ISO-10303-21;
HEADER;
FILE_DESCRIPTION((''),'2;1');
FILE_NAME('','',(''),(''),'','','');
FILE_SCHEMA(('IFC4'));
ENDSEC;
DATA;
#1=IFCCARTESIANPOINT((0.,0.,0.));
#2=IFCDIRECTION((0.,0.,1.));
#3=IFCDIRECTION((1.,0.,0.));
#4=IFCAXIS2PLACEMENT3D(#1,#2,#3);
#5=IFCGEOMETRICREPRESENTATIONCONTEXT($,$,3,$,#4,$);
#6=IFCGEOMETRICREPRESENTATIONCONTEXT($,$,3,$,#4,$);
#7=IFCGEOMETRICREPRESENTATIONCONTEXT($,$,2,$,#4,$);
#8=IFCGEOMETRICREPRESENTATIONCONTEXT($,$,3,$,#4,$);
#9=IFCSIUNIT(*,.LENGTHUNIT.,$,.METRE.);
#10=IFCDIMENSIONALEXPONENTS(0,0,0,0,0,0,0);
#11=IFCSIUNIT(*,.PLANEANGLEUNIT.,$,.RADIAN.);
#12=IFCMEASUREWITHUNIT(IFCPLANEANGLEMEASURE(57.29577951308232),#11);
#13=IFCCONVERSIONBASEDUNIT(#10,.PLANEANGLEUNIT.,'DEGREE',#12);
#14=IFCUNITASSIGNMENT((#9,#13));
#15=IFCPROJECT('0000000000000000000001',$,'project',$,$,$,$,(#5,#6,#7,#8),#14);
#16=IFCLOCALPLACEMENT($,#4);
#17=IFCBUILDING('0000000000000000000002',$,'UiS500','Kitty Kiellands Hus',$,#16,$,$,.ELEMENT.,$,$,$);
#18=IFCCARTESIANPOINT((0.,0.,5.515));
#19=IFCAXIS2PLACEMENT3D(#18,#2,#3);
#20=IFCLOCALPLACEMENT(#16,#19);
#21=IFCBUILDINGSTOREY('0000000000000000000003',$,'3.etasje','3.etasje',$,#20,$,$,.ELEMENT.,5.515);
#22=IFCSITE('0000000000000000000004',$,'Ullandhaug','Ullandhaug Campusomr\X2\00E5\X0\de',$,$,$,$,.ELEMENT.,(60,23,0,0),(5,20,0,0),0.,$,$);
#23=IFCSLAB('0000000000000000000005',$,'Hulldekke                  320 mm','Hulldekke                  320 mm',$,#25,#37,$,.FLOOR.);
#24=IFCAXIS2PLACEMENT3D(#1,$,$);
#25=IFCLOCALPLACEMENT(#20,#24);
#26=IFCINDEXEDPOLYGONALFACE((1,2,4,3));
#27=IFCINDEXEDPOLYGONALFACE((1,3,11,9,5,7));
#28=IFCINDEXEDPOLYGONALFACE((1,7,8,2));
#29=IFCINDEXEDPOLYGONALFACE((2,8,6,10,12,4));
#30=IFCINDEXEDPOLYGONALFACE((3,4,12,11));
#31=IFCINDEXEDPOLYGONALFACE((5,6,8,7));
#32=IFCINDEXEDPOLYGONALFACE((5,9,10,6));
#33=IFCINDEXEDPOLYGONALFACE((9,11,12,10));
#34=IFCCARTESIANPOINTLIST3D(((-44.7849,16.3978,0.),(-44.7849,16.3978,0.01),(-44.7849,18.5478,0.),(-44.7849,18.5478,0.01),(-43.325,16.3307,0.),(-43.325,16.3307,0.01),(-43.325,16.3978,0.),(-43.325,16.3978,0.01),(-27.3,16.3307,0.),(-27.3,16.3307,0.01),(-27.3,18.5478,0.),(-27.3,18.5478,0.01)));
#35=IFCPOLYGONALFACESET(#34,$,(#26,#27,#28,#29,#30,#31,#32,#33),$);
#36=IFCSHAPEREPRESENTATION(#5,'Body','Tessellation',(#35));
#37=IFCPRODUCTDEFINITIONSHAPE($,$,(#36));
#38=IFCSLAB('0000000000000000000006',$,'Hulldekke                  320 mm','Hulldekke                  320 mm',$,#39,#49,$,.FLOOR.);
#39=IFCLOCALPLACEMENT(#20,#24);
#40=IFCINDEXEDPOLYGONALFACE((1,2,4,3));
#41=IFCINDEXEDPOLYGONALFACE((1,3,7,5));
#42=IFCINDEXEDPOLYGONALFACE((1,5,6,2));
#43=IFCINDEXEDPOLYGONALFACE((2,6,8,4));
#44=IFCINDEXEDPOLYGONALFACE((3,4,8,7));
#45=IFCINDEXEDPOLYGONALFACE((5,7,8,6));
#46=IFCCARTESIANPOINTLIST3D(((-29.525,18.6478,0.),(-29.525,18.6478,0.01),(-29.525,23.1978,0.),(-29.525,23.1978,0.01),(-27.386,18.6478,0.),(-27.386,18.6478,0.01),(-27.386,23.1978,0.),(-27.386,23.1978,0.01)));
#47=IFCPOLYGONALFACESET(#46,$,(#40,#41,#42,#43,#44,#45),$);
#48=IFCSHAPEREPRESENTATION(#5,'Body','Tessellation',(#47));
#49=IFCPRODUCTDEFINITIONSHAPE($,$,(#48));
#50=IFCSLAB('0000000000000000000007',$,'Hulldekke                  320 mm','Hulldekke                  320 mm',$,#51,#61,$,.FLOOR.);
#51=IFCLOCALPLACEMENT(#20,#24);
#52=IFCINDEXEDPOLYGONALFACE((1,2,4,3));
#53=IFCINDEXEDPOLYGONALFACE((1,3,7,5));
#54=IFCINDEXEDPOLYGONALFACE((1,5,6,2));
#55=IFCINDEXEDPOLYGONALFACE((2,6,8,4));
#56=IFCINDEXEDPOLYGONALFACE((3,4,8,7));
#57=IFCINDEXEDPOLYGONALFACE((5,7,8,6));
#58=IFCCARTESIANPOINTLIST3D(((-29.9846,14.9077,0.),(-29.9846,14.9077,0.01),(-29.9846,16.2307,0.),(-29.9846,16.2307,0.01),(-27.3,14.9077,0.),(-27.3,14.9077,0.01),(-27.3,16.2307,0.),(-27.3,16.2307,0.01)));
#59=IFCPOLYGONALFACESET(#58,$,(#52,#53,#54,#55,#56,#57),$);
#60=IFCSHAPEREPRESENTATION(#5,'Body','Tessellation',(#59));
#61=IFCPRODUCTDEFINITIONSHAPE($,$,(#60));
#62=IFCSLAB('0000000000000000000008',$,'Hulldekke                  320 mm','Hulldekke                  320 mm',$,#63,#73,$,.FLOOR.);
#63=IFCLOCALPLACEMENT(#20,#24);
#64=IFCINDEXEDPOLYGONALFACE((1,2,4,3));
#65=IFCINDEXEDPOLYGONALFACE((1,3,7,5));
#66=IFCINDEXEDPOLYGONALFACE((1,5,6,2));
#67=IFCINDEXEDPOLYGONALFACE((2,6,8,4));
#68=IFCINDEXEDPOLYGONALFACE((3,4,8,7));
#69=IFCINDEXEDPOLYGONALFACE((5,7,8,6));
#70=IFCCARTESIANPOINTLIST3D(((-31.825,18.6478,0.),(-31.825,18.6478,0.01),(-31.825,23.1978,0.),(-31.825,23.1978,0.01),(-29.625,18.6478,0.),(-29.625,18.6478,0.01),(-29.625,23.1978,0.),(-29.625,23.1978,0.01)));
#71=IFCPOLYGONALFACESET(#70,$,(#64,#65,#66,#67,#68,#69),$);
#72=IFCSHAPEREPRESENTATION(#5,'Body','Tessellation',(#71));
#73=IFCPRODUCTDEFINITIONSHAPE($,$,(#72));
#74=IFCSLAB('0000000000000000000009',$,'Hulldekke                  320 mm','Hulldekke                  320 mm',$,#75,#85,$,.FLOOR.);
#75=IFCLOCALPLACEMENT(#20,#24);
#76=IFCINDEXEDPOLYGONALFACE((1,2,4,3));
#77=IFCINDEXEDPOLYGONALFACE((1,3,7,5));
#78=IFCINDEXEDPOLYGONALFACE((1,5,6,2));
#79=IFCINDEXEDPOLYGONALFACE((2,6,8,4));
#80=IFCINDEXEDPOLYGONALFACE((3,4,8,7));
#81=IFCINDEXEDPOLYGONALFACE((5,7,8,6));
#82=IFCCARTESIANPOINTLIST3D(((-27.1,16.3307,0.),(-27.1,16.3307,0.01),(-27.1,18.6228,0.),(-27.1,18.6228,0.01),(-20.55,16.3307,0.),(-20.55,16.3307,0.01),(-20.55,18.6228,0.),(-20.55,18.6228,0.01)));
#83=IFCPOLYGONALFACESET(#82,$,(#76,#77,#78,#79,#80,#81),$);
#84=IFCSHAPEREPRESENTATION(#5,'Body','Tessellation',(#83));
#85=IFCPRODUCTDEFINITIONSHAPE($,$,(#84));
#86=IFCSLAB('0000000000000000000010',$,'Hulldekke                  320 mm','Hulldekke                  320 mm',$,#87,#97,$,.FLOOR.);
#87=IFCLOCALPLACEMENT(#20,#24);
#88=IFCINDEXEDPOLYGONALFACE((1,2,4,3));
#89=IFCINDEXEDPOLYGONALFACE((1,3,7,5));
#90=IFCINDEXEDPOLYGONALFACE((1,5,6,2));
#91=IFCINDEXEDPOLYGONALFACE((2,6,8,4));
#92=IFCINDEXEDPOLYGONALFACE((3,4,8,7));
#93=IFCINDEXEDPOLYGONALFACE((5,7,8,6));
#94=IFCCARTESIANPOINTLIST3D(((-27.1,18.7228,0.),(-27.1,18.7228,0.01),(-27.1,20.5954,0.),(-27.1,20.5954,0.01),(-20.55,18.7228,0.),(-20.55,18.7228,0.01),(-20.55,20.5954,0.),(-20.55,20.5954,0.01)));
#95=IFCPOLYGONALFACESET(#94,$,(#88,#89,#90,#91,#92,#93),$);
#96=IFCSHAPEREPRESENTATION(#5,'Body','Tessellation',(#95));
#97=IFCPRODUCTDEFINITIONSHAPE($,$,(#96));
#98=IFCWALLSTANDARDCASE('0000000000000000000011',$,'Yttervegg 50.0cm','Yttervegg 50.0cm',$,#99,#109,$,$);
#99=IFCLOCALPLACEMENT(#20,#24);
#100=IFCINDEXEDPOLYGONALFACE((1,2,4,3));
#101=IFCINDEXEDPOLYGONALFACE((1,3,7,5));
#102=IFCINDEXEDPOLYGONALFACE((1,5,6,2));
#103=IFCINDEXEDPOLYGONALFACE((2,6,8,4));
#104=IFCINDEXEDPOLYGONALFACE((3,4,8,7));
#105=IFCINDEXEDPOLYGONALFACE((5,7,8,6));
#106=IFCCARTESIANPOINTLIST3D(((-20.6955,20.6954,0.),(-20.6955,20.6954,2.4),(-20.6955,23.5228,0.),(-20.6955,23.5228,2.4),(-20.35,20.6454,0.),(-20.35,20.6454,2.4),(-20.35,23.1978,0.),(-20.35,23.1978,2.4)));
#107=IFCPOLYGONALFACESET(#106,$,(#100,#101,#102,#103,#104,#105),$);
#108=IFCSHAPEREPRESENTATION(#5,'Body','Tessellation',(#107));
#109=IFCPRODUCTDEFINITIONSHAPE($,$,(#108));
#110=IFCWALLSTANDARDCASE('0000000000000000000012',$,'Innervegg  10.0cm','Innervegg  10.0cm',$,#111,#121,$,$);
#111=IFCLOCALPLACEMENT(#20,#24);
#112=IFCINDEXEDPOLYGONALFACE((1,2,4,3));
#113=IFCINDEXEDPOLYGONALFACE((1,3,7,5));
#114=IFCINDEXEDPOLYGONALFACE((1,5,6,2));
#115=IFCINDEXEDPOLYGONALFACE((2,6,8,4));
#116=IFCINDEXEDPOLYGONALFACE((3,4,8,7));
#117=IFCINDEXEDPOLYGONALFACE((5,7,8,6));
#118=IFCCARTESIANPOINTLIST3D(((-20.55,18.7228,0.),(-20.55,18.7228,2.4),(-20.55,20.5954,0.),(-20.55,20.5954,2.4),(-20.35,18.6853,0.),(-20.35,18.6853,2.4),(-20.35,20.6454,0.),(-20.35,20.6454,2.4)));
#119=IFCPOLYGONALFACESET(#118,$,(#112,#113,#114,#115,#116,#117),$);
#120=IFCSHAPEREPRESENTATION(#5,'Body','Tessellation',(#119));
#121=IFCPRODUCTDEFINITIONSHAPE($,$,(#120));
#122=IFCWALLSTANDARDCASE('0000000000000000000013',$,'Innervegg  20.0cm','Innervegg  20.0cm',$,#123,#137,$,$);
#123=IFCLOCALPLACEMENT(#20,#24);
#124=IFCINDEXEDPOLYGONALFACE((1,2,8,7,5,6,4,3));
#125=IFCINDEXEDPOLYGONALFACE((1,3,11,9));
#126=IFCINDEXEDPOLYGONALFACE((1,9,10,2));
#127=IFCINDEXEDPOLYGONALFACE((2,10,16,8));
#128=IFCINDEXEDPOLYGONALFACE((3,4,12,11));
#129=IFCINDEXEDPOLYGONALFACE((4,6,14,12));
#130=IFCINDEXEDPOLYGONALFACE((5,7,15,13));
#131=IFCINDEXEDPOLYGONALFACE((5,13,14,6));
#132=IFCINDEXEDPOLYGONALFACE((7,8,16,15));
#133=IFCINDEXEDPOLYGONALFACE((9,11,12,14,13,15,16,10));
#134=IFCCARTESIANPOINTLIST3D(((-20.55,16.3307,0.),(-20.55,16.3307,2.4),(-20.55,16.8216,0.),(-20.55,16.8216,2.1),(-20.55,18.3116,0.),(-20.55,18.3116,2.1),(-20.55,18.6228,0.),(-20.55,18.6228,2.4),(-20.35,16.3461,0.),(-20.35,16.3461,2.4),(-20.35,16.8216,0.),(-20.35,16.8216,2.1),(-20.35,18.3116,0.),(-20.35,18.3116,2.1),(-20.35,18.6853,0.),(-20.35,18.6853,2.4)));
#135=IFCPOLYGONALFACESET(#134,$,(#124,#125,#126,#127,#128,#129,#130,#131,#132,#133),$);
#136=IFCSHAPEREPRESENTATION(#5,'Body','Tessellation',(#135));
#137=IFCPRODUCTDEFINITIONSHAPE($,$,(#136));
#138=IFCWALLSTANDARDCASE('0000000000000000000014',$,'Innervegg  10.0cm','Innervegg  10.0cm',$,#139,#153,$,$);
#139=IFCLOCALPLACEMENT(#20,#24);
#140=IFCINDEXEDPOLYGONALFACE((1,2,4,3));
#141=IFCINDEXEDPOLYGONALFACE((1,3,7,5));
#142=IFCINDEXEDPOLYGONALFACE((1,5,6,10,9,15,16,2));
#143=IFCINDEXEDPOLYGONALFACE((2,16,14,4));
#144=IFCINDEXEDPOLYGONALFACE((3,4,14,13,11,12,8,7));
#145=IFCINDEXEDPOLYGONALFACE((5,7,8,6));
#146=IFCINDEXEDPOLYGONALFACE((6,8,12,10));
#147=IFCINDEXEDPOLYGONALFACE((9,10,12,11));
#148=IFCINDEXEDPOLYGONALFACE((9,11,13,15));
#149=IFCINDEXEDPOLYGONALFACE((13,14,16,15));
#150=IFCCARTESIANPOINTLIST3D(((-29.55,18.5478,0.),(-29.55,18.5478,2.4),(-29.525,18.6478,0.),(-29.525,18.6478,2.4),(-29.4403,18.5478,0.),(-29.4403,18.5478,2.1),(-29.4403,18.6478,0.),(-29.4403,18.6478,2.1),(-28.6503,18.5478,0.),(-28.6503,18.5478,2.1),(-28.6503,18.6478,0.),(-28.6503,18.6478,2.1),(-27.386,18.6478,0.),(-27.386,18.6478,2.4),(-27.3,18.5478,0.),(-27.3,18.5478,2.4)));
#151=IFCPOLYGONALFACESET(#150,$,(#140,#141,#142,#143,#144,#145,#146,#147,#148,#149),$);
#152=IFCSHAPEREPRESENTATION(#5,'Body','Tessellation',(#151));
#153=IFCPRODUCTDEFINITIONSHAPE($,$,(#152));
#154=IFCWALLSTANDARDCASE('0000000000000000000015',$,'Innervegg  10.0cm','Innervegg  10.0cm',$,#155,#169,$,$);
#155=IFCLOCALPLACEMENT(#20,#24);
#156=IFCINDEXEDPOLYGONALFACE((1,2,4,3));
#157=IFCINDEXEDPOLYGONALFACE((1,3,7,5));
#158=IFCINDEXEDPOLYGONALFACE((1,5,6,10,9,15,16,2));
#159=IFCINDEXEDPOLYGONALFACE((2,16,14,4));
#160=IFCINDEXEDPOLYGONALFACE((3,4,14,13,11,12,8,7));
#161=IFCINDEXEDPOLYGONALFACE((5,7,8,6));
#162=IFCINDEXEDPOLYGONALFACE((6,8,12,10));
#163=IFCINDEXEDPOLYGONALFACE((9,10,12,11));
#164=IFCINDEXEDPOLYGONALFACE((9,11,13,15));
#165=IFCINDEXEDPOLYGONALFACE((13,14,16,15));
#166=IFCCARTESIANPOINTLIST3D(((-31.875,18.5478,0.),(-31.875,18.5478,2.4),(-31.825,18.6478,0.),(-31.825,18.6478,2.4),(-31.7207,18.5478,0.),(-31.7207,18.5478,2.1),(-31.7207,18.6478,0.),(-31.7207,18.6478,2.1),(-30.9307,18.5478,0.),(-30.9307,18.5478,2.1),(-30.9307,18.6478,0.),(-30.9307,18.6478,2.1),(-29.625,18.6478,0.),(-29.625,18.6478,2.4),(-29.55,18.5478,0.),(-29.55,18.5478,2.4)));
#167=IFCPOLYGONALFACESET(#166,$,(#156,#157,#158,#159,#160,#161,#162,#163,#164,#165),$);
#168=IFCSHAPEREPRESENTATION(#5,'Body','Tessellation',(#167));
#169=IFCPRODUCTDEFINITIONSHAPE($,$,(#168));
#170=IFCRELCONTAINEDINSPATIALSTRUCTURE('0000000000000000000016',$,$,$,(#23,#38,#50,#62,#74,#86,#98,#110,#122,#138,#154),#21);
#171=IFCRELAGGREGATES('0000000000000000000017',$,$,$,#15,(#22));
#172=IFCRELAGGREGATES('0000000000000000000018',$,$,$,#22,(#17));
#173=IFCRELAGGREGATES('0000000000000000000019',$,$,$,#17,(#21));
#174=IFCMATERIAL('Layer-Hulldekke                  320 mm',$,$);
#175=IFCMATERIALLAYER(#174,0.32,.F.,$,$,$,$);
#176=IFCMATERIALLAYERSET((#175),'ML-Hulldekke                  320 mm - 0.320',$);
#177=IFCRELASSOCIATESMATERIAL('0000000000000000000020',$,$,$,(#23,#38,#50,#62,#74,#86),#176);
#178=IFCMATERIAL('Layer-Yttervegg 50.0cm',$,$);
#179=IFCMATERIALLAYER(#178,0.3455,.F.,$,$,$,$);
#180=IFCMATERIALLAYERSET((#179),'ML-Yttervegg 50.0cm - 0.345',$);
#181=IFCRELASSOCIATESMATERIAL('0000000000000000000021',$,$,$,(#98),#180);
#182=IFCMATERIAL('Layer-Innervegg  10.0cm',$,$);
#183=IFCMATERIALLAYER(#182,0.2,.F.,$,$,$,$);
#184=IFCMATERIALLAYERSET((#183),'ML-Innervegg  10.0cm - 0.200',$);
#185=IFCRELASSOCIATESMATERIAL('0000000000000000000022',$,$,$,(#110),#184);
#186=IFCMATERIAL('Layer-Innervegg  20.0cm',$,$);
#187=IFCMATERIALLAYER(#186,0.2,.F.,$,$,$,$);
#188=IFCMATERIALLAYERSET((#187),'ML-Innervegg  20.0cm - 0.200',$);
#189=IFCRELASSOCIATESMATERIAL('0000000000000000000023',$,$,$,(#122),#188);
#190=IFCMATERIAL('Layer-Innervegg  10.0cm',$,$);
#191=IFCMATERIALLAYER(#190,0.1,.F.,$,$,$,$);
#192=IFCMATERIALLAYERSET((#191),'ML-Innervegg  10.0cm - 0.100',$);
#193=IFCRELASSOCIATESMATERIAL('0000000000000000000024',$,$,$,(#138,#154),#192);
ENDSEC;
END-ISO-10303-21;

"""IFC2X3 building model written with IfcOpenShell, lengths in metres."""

from ifc_helpers import new_model, entity, si_unit, converted_unit, frame, origin_with_axes, place, context, project, spatial, polyline, outline, extrude, material, layer, layer_set, layer_usage, element, save


model = new_model("IFC2X3")

# Units and contexts
context_of_model_1 = context(None, 3, world=origin_with_axes())
context_of_model_2 = context(None, 3, world=origin_with_axes())
context_of_model_3 = context(None, 2, world=origin_with_axes())
context_of_model_4 = context(None, 3, world=origin_with_axes())
ifc_project = project(units=[si_unit("LENGTHUNIT", "METRE"), converted_unit("PLANEANGLEUNIT", "DEGREE", entity("IfcPlaneAngleMeasure", 57.29577951308232), si_unit("PLANEANGLEUNIT", "RADIAN"), dimensions=[0, 0, 0, 0, 0, 0, 0])], contexts=[context_of_model_1, context_of_model_2, context_of_model_3, context_of_model_4])

# Site, building, storey
site = spatial("IfcSite", under=ifc_project, Name="Ullandhaug", Description="Ullandhaug Campusområde", CompositionType="ELEMENT", RefLatitude=(60, 23, 0, 0), RefLongitude=(5, 20, 0, 0), RefElevation=0.0)
building_placement = place(None, origin_with_axes())
building = spatial("IfcBuilding", under=site, at=building_placement, Name="UiS500", Description="Kitty Kiellands Hus", CompositionType="ELEMENT")
storey_placement = place(building_placement, frame((0.0, 0.0, 5.515), z_axis=(0.0, 0.0, 1.0), x_axis=(1.0, 0.0, 0.0)))
storey = spatial("IfcBuildingStorey", under=building, at=storey_placement, Name="3.etasje", Description="3.etasje", CompositionType="ELEMENT", Elevation=5.515)

# Slabs
ifc_material_1 = material(Name="Layer-Hulldekke                  320 mm")
ifc_layer_1 = layer(ifc_material_1, 0.32, ventilated=False)
ifc_layer_set_1 = layer_set([ifc_layer_1], Name="ML-Hulldekke                  320 mm - 0.320")
ifc_layer_usage_1 = layer_usage(ifc_layer_set_1, "AXIS2", "POSITIVE", 0.0)
slab_1_placement = place(storey_placement, frame((-27.3, 18.5478, 0.0), z_axis=(0.0, 0.0, 1.0), x_axis=(1.0, 0.0, 0.0)))
element("IfcSlab", 1, at=slab_1_placement, inside=storey, material=ifc_layer_usage_1, Name="Hulldekke                  320 mm", Description="Hulldekke                  320 mm", PredefinedType="FLOOR", context=context_of_model_1, shape_type="SweptSolid", body=[
    extrude(outline(polyline([(0.0, 0.0), (17.4849, 0.0), (17.4849, 2.15), (16.025, 2.15), (16.025, 2.217), (0.0, 2.217), (0.0, 0.0)])), frame((0.0, 0.0, 0.0), z_axis=(0.0, 0.0, 1.0), x_axis=(-1.0, 0.0, 0.0)), (0.0, 0.0, 1.0), 0.01),
])
slab_2_placement = place(storey_placement, frame((-29.525, 23.1978, 0.0), z_axis=(0.0, 0.0, 1.0), x_axis=(1.0, 0.0, 0.0)))
element("IfcSlab", 2, at=slab_2_placement, inside=storey, material=ifc_layer_usage_1, Name="Hulldekke                  320 mm", Description="Hulldekke                  320 mm", PredefinedType="FLOOR", context=context_of_model_1, shape_type="SweptSolid", body=[
    extrude(outline(polyline([(0.0, 0.0), (4.55, 0.0), (4.55, 2.139), (0.0, 2.139), (0.0, 0.0)])), frame((0.0, 0.0, 0.0), z_axis=(0.0, 0.0, 1.0), x_axis=(0.0, -1.0, 0.0)), (0.0, 0.0, 1.0), 0.01),
])
slab_3_placement = place(storey_placement, frame((-29.9846, 14.9077, 0.0), z_axis=(0.0, 0.0, 1.0), x_axis=(1.0, 0.0, 0.0)))
element("IfcSlab", 3, at=slab_3_placement, inside=storey, material=ifc_layer_usage_1, Name="Hulldekke                  320 mm", Description="Hulldekke                  320 mm", PredefinedType="FLOOR", context=context_of_model_1, shape_type="SweptSolid", body=[
    extrude(outline(polyline([(0.0, 0.0), (2.6846, 0.0), (2.6846, 1.323), (0.0, 1.323), (0.0, 0.0)])), origin_with_axes(), (0.0, 0.0, 1.0), 0.01),
])
slab_4_placement = place(storey_placement, frame((-29.625, 23.1978, 0.0), z_axis=(0.0, 0.0, 1.0), x_axis=(1.0, 0.0, 0.0)))
element("IfcSlab", 4, at=slab_4_placement, inside=storey, material=ifc_layer_usage_1, Name="Hulldekke                  320 mm", Description="Hulldekke                  320 mm", PredefinedType="FLOOR", context=context_of_model_1, shape_type="SweptSolid", body=[
    extrude(outline(polyline([(0.0, 0.0), (2.2, 0.0), (2.2, 4.55), (0.0, 4.55), (0.0, 0.0)])), frame((0.0, 0.0, 0.0), z_axis=(0.0, 0.0, 1.0), x_axis=(-1.0, 0.0, 0.0)), (0.0, 0.0, 1.0), 0.01),
])
slab_5_placement = place(storey_placement, frame((-27.1, 18.6228, 0.0), z_axis=(0.0, 0.0, 1.0), x_axis=(1.0, 0.0, 0.0)))
element("IfcSlab", 5, at=slab_5_placement, inside=storey, material=ifc_layer_usage_1, Name="Hulldekke                  320 mm", Description="Hulldekke                  320 mm", PredefinedType="FLOOR", context=context_of_model_1, shape_type="SweptSolid", body=[
    extrude(outline(polyline([(0.0, 0.0), (2.292, 0.0), (2.292, 6.55), (0.0, 6.55), (0.0, 0.0)])), frame((0.0, 0.0, 0.0), z_axis=(0.0, 0.0, 1.0), x_axis=(0.0, -1.0, 0.0)), (0.0, 0.0, 1.0), 0.01),
])
slab_6_placement = place(storey_placement, frame((-27.1, 20.5954, 0.0), z_axis=(0.0, 0.0, 1.0), x_axis=(1.0, 0.0, 0.0)))
element("IfcSlab", 6, at=slab_6_placement, inside=storey, material=ifc_layer_usage_1, Name="Hulldekke                  320 mm", Description="Hulldekke                  320 mm", PredefinedType="FLOOR", context=context_of_model_1, shape_type="SweptSolid", body=[
    extrude(outline(polyline([(0.0, 0.0), (1.8727, 0.0), (1.8727, 6.55), (0.0, 6.55), (0.0, 0.0)])), frame((0.0, 0.0, 0.0), z_axis=(0.0, 0.0, 1.0), x_axis=(0.0, -1.0, 0.0)), (0.0, 0.0, 1.0), 0.01),
])

# Walls
ifc_material_2 = material(Name="Layer-Yttervegg 50.0cm")
ifc_layer_2 = layer(ifc_material_2, 0.3455, ventilated=False)
ifc_layer_set_2 = layer_set([ifc_layer_2], Name="ML-Yttervegg 50.0cm - 0.345")
ifc_layer_usage_2 = layer_usage(ifc_layer_set_2, "AXIS2", "POSITIVE", 0.0)
wall_1_placement = place(storey_placement, frame((-20.6955, 23.5228, 0.0), z_axis=(0.0, 0.0, 1.0), x_axis=(0.0, -1.0, 0.0)))
element("IfcWallStandardCase", 7, at=wall_1_placement, inside=storey, material=ifc_layer_usage_2, Name="Yttervegg 50.0cm", Description="Yttervegg 50.0cm", context=context_of_model_1, shape_type="SweptSolid", body=[
    extrude(outline(polyline([(0.0, 0.0), (2.8273, 0.0), (2.8773, 0.3455), (0.325, 0.3455), (0.0, 0.0)])), frame((0.0, 0.0, 0.0), z_axis=(0.0, 0.0, 1.0), x_axis=(1.0, 0.0, 0.0)), (0.0, 0.0, 1.0), 2.4),
])
ifc_material_3 = material(Name="Layer-Innervegg  10.0cm")
ifc_layer_3 = layer(ifc_material_3, 0.2, ventilated=False)
ifc_layer_set_3 = layer_set([ifc_layer_3], Name="ML-Innervegg  10.0cm - 0.200")
ifc_layer_usage_3 = layer_usage(ifc_layer_set_3, "AXIS2", "POSITIVE", 0.0)
wall_2_placement = place(storey_placement, frame((-20.55, 20.5954, 0.0), z_axis=(0.0, 0.0, 1.0), x_axis=(0.0, -1.0, 0.0)))
element("IfcWallStandardCase", 8, at=wall_2_placement, inside=storey, material=ifc_layer_usage_3, Name="Innervegg  10.0cm", Description="Innervegg  10.0cm", context=context_of_model_1, shape_type="SweptSolid", body=[
    extrude(outline(polyline([(0.0, 0.0), (1.8727, 0.0), (1.9102, 0.2), (-0.05, 0.2), (0.0, 0.0)])), frame((0.0, 0.0, 0.0), z_axis=(0.0, 0.0, 1.0), x_axis=(1.0, 0.0, 0.0)), (0.0, 0.0, 1.0), 2.4),
])

# Walls, openings
ifc_material_4 = material(Name="Layer-Innervegg  20.0cm")
ifc_layer_4 = layer(ifc_material_4, 0.2, ventilated=False)
ifc_layer_set_4 = layer_set([ifc_layer_4], Name="ML-Innervegg  20.0cm - 0.200")
ifc_layer_usage_4 = layer_usage(ifc_layer_set_4, "AXIS2", "POSITIVE", 0.0)
wall_3_placement = place(storey_placement, frame((-20.55, 18.6228, 0.0), z_axis=(0.0, 0.0, 1.0), x_axis=(0.0, -1.0, 0.0)))
wall_3 = element("IfcWallStandardCase", 9, at=wall_3_placement, inside=storey, material=ifc_layer_usage_4, Name="Innervegg  20.0cm", Description="Innervegg  20.0cm", context=context_of_model_1, shape_type="SweptSolid", body=[
    extrude(outline(polyline([(0.0, 0.0), (2.292, 0.0), (2.2767, 0.2), (-0.0625, 0.2), (0.0, 0.0)])), frame((0.0, 0.0, 0.0), z_axis=(0.0, 0.0, 1.0), x_axis=(1.0, 0.0, 0.0)), (0.0, 0.0, 1.0), 2.4),
])
opening_1_placement = place(wall_3_placement, frame((0.3111, 0.2, 0.0), z_axis=(0.0, 0.0, 1.0), x_axis=(1.0, 0.0, 0.0)))
element("IfcOpeningElement", 10, at=opening_1_placement, cuts=wall_3, context=context_of_model_1, shape_type="SweptSolid", body=[
    extrude(outline(polyline([(0.0, 0.0), (2.1, 0.0), (2.1, 1.49), (0.0, 1.49), (0.0, 0.0)])), frame((0.0, 0.0, 0.0), z_axis=(0.0, 1.0, 0.0), x_axis=(0.0, 0.0, 1.0)), (0.0, 0.0, -1.0), 0.2),
])
ifc_material_5 = material(Name="Layer-Innervegg  10.0cm")
ifc_layer_5 = layer(ifc_material_5, 0.1, ventilated=False)
ifc_layer_set_5 = layer_set([ifc_layer_5], Name="ML-Innervegg  10.0cm - 0.100")
ifc_layer_usage_5 = layer_usage(ifc_layer_set_5, "AXIS2", "POSITIVE", 0.0)
wall_4_placement = place(storey_placement, frame((-27.386, 18.6478, 0.0), z_axis=(0.0, 0.0, 1.0), x_axis=(-1.0, 0.0, 0.0)))
wall_4 = element("IfcWallStandardCase", 11, at=wall_4_placement, inside=storey, material=ifc_layer_usage_5, Name="Innervegg  10.0cm", Description="Innervegg  10.0cm", context=context_of_model_1, shape_type="SweptSolid", body=[
    extrude(outline(polyline([(0.0, 0.0), (2.139, 0.0), (2.164, 0.1), (-0.086, 0.1), (0.0, 0.0)])), frame((0.0, 0.0, 0.0), z_axis=(0.0, 0.0, 1.0), x_axis=(1.0, 0.0, 0.0)), (0.0, 0.0, 1.0), 2.4),
])
opening_2_placement = place(wall_4_placement, frame((1.2643, 0.1, 0.0), z_axis=(0.0, 0.0, 1.0), x_axis=(1.0, 0.0, 0.0)))
element("IfcOpeningElement", 12, at=opening_2_placement, cuts=wall_4, context=context_of_model_1, shape_type="SweptSolid", body=[
    extrude(outline(polyline([(0.0, 0.0), (2.1, 0.0), (2.1, 0.79), (0.0, 0.79), (0.0, 0.0)])), frame((0.0, 0.0, 0.0), z_axis=(0.0, 1.0, 0.0), x_axis=(0.0, 0.0, 1.0)), (0.0, 0.0, -1.0), 0.1),
])
wall_5_placement = place(storey_placement, frame((-29.625, 18.6478, 0.0), z_axis=(0.0, 0.0, 1.0), x_axis=(-1.0, 0.0, 0.0)))
wall_5 = element("IfcWallStandardCase", 13, at=wall_5_placement, inside=storey, material=ifc_layer_usage_5, Name="Innervegg  10.0cm", Description="Innervegg  10.0cm", context=context_of_model_1, shape_type="SweptSolid", body=[
    extrude(outline(polyline([(0.0, 0.0), (2.2, 0.0), (2.25, 0.1), (-0.075, 0.1), (0.0, 0.0)])), frame((0.0, 0.0, 0.0), z_axis=(0.0, 0.0, 1.0), x_axis=(1.0, 0.0, 0.0)), (0.0, 0.0, 1.0), 2.4),
])
opening_3_placement = place(wall_5_placement, frame((1.3057, 0.1, 0.0), z_axis=(0.0, 0.0, 1.0), x_axis=(1.0, 0.0, 0.0)))
element("IfcOpeningElement", 14, at=opening_3_placement, cuts=wall_5, context=context_of_model_1, shape_type="SweptSolid", body=[
    extrude(outline(polyline([(0.0, 0.0), (2.1, 0.0), (2.1, 0.79), (0.0, 0.79), (0.0, 0.0)])), frame((0.0, 0.0, 0.0), z_axis=(0.0, 1.0, 0.0), x_axis=(0.0, 0.0, 1.0)), (0.0, 0.0, -1.0), 0.1),
])

save(model, "model.ifc")
